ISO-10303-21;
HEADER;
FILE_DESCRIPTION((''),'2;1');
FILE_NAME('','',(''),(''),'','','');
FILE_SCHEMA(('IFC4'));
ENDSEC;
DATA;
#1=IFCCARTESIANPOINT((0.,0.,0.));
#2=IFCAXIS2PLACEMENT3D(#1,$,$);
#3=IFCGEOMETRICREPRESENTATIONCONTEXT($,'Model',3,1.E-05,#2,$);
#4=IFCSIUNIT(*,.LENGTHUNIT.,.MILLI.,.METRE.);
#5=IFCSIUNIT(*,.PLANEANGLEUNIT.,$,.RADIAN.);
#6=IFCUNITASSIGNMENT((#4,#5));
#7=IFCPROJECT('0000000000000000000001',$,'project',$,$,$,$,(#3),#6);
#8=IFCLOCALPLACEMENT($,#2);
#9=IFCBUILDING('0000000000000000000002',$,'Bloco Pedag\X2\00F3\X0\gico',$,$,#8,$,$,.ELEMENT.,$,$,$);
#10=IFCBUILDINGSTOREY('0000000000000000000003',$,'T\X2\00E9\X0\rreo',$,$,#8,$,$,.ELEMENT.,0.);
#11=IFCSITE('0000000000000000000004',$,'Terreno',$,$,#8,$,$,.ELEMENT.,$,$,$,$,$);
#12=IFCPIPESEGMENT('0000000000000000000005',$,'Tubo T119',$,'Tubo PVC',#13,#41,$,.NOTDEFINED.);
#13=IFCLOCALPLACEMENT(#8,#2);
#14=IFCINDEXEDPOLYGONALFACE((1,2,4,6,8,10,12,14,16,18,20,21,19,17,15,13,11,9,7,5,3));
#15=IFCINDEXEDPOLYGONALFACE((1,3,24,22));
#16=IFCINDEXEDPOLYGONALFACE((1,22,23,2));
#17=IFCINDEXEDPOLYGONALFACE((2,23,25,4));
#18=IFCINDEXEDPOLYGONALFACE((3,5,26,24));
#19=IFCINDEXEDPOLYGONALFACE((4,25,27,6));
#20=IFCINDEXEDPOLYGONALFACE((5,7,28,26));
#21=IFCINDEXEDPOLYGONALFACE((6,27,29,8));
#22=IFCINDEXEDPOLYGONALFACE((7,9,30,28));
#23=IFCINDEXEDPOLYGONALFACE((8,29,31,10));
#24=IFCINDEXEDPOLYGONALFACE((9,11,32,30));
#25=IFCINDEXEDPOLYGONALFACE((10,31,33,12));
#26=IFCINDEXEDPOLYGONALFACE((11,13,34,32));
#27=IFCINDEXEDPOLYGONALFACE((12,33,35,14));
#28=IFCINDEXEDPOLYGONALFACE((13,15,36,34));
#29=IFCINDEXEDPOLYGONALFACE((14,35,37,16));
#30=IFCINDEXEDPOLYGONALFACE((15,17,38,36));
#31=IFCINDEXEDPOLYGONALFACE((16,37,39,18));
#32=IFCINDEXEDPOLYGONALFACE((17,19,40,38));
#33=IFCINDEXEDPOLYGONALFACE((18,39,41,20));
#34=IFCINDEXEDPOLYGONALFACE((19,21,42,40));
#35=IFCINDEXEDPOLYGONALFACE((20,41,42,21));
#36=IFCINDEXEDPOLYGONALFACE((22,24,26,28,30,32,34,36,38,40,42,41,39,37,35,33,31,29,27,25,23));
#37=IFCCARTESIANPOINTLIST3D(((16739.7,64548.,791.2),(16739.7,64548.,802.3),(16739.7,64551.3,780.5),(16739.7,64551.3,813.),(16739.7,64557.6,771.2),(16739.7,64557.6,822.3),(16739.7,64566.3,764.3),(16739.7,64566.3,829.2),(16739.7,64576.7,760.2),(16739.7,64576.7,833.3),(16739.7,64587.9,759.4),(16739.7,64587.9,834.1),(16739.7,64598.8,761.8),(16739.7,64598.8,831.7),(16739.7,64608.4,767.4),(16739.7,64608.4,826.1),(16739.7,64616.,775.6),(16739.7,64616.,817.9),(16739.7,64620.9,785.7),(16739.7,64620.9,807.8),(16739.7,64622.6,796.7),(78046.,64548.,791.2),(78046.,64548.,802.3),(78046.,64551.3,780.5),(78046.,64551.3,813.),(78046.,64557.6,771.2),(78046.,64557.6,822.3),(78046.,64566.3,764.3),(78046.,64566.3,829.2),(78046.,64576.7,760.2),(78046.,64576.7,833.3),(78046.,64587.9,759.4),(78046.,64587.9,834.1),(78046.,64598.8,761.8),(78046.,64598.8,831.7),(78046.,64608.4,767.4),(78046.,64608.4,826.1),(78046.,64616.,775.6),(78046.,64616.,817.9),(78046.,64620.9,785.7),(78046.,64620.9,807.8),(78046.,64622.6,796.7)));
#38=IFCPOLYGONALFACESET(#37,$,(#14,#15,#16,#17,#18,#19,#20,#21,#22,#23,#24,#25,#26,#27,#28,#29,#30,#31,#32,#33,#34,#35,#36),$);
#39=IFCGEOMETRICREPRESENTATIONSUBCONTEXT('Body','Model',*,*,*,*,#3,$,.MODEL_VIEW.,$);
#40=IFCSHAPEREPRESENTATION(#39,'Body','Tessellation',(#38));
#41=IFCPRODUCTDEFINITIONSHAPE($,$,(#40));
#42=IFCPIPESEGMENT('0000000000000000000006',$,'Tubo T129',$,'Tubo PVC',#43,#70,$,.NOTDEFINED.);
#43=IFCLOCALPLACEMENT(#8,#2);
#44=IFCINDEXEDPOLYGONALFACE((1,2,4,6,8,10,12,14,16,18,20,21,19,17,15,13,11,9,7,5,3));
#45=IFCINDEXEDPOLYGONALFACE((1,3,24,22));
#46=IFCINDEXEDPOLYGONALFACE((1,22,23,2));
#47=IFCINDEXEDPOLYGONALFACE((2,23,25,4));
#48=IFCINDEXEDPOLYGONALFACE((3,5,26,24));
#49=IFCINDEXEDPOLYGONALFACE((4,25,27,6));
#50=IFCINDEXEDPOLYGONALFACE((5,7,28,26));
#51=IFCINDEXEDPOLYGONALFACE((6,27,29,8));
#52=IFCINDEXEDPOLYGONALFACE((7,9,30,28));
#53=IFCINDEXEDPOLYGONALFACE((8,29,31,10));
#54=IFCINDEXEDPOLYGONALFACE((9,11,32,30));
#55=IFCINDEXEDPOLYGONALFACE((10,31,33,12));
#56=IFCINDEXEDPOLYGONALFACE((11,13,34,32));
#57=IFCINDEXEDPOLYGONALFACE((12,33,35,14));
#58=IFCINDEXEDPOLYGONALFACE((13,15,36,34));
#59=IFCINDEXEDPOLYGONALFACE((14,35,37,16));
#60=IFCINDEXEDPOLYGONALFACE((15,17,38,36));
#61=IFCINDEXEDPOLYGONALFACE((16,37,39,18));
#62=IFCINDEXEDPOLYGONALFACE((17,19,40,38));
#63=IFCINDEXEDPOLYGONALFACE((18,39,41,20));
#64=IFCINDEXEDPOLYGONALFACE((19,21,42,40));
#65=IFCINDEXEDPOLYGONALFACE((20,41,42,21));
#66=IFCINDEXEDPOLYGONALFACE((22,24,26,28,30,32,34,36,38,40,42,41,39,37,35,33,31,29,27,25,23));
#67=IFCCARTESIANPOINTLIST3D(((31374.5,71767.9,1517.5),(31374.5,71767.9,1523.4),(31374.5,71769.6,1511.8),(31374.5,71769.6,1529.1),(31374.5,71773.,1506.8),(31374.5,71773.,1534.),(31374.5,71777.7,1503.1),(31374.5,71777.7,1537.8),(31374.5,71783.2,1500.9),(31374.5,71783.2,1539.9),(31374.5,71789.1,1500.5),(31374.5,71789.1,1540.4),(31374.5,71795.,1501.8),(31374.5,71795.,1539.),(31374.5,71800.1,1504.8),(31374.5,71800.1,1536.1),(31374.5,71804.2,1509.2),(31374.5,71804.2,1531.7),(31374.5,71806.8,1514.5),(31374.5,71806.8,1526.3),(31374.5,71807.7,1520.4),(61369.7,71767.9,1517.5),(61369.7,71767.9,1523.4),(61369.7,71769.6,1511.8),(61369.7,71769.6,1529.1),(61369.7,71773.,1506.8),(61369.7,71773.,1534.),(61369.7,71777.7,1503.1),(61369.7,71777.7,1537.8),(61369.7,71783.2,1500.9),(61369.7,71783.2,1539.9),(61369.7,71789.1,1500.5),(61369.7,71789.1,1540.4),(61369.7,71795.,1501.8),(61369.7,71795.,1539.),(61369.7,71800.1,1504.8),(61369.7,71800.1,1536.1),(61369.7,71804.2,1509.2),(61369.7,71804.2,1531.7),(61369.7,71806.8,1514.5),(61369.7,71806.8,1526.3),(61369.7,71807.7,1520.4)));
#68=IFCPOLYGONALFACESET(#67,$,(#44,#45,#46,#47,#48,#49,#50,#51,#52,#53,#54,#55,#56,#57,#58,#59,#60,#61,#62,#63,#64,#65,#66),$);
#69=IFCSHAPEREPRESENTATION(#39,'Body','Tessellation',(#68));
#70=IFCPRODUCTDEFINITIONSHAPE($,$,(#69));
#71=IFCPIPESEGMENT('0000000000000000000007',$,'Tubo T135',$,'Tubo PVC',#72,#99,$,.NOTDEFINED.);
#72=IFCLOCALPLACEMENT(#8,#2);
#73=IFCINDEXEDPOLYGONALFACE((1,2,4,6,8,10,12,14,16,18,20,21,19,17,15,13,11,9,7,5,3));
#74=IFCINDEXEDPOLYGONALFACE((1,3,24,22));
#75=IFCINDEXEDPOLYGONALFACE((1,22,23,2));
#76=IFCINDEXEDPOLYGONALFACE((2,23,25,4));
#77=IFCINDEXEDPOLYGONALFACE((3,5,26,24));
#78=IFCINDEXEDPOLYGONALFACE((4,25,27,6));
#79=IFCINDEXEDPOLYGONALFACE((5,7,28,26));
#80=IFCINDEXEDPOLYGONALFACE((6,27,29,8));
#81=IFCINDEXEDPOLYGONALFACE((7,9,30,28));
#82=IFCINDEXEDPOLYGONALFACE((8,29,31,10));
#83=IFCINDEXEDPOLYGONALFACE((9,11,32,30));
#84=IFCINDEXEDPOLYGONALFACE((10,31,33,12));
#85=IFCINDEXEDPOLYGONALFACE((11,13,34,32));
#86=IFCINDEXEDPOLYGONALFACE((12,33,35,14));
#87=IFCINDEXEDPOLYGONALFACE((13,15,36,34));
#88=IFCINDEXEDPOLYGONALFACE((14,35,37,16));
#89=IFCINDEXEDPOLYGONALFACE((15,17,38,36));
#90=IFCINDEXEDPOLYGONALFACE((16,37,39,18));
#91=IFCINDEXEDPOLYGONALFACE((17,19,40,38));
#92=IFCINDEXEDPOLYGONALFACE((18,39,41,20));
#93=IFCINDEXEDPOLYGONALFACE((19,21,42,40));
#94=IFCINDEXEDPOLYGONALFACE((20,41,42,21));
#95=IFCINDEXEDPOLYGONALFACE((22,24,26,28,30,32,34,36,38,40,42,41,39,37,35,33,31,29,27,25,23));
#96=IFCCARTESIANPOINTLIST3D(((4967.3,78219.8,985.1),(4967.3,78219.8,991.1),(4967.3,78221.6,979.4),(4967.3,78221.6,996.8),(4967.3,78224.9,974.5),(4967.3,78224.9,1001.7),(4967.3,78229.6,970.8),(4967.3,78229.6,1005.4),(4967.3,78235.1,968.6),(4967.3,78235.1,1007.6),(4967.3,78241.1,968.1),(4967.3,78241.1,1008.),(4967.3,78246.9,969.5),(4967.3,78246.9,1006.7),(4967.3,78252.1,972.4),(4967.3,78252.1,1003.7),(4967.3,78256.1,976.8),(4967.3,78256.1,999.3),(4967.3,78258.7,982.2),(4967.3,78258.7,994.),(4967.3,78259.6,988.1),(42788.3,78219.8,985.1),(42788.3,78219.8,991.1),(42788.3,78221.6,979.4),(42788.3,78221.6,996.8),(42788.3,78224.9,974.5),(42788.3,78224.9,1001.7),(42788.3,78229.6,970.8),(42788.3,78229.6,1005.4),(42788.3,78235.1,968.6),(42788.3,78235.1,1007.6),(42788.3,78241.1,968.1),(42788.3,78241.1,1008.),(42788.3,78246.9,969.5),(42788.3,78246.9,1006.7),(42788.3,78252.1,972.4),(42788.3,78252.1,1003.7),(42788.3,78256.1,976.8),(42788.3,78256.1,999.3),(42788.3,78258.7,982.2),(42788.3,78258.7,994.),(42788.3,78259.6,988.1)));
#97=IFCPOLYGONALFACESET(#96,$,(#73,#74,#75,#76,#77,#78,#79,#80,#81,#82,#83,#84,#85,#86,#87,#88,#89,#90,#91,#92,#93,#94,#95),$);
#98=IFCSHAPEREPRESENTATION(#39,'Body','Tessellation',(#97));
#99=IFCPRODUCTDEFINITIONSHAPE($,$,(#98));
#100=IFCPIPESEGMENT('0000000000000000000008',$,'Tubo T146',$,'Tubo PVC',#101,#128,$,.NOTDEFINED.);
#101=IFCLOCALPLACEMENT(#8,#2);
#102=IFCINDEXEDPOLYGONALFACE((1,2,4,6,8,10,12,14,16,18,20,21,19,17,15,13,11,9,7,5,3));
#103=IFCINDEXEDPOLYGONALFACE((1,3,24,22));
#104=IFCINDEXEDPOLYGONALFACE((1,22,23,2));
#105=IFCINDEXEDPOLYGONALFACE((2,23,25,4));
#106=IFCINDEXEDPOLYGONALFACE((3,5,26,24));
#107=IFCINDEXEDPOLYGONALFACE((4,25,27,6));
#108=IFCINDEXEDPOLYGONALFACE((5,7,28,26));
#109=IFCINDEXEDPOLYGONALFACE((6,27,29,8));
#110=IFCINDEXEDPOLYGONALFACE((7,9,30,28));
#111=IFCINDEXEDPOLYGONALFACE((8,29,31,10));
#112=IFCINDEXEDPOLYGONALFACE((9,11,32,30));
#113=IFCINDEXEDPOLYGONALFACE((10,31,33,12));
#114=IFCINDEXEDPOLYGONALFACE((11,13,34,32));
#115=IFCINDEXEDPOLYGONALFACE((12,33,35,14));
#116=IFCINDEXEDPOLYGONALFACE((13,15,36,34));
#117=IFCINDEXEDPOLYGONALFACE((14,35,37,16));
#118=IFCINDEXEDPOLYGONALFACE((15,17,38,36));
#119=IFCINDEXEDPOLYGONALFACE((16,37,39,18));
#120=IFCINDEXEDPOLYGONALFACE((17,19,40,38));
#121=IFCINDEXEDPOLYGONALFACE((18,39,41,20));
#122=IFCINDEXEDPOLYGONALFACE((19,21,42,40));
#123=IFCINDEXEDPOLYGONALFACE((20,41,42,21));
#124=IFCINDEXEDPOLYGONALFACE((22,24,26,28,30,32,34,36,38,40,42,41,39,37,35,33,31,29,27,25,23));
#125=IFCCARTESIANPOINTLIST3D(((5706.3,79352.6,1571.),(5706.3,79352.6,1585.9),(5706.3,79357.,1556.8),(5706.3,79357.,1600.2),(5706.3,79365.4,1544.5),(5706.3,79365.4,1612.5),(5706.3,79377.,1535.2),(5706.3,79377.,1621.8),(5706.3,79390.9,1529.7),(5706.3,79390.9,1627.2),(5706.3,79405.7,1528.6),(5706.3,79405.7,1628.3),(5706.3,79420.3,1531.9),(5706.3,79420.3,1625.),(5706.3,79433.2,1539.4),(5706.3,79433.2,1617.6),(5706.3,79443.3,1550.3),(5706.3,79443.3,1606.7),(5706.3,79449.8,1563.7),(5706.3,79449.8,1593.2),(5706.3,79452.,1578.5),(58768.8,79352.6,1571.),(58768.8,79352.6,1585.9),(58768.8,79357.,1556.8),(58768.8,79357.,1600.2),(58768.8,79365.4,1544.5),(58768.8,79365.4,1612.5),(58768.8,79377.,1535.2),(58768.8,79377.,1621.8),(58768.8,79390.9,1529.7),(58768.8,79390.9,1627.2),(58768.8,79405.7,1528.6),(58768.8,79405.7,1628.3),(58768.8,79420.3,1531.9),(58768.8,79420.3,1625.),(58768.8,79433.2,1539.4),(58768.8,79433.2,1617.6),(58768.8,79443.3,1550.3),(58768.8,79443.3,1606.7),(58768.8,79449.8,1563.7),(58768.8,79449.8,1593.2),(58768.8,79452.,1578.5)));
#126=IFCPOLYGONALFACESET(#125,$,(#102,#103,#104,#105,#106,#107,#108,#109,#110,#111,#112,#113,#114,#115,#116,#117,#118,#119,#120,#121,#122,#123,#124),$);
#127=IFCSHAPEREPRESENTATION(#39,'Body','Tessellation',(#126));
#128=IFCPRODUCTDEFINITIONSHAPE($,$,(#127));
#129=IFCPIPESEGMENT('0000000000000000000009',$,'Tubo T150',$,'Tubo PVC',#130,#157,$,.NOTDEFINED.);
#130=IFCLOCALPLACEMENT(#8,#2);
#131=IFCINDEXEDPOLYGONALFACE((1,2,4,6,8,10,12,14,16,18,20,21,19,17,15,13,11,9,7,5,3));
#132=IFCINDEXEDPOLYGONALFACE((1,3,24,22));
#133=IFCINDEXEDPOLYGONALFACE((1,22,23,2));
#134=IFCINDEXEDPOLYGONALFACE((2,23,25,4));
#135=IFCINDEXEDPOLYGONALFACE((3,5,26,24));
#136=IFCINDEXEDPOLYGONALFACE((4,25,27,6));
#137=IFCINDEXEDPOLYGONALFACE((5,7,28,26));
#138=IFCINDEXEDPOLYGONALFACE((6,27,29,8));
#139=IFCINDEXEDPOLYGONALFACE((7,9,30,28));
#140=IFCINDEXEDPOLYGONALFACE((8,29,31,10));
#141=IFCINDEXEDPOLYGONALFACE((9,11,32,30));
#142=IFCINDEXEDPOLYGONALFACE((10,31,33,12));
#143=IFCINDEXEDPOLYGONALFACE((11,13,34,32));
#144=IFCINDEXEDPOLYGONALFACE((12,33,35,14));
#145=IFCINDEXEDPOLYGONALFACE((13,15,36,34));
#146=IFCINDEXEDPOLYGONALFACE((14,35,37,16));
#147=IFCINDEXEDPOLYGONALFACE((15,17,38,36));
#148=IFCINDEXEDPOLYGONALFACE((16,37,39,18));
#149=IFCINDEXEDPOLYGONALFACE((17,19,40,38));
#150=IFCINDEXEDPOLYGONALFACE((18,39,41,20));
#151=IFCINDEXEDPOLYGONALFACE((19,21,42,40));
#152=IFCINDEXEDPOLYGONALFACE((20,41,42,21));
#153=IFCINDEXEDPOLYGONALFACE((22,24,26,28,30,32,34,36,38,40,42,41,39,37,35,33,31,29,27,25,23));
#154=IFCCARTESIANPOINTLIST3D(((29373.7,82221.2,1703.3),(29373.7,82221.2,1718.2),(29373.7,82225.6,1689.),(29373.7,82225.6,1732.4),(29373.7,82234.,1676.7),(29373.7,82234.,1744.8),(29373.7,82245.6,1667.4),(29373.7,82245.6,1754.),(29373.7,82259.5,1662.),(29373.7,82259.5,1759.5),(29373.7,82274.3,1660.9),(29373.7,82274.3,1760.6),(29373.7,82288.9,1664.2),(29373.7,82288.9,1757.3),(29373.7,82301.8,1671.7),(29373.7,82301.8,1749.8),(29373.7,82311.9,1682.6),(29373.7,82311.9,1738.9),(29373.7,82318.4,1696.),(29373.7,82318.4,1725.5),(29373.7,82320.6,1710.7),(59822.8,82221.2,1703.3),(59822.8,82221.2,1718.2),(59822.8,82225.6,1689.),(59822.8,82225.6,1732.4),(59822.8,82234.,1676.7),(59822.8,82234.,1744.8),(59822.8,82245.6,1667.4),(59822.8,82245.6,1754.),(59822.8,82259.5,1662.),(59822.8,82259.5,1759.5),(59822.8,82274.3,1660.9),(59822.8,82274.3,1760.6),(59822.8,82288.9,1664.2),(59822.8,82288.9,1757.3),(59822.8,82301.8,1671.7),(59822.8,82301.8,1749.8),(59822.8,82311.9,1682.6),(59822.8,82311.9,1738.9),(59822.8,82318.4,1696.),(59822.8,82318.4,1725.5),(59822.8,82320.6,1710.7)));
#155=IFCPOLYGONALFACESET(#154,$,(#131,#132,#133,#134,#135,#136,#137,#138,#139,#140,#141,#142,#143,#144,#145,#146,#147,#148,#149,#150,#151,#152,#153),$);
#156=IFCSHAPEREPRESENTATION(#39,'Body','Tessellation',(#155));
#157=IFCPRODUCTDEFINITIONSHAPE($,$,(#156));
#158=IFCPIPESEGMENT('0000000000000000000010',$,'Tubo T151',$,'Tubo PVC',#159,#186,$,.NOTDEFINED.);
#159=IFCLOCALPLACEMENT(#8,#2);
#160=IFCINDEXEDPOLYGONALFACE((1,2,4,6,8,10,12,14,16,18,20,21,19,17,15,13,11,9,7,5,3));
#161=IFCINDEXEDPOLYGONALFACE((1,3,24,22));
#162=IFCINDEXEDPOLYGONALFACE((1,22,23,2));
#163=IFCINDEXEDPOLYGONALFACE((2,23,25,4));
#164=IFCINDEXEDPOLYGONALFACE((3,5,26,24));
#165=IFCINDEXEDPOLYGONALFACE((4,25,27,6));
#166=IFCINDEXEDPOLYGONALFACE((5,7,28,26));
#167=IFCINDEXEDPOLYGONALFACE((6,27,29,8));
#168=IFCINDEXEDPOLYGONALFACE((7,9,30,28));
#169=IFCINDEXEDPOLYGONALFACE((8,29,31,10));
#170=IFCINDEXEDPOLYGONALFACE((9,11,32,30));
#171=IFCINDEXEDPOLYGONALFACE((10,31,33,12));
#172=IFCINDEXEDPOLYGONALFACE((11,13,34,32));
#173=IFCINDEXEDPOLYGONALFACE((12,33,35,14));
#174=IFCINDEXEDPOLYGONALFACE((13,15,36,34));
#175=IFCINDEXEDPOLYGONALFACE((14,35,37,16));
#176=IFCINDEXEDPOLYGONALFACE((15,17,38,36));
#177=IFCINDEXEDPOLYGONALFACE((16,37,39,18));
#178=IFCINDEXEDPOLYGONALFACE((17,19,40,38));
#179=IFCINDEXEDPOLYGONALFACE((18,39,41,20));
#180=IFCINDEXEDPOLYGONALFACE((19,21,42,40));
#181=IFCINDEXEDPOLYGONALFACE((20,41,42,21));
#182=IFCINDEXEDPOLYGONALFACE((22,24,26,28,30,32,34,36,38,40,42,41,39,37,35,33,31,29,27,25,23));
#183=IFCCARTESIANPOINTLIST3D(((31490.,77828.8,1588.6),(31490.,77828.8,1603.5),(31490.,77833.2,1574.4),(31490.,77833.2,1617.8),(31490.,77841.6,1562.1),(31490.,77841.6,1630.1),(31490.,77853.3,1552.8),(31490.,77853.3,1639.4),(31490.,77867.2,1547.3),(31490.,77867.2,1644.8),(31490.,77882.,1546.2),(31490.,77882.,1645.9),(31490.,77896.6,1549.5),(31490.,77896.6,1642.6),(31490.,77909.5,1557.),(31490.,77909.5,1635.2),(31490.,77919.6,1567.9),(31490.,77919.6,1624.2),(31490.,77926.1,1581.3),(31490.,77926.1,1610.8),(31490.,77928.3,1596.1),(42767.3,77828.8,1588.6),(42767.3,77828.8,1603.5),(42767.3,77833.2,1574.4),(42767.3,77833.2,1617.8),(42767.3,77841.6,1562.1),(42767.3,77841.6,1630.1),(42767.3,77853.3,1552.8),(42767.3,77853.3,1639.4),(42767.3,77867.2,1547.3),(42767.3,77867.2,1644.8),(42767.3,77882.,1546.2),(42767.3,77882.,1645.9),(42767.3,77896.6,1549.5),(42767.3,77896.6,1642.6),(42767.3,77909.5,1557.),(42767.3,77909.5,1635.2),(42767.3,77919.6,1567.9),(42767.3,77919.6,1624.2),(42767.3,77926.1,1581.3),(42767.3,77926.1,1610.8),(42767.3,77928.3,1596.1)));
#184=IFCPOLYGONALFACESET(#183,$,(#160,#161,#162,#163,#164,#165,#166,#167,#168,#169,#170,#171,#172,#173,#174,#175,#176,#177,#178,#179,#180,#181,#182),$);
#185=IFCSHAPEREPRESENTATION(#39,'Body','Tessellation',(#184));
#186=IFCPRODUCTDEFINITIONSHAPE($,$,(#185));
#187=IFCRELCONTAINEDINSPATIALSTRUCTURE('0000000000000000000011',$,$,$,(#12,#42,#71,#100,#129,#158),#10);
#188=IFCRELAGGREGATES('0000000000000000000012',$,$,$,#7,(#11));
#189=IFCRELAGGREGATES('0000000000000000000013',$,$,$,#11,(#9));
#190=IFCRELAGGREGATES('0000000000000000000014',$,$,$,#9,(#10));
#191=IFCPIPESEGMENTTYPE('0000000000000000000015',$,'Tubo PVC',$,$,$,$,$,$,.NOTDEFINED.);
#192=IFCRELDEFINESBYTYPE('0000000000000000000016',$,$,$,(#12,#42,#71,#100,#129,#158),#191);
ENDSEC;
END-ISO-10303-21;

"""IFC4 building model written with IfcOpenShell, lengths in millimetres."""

from ifc_helpers import new_model, si_unit, frame, origin, origin_2d, place, context, subcontext, project, spatial, circle, extrude, type_object, element, save


model = new_model("IFC4")

# Units and contexts
model_context = context("Model", 3, precision=1e-05, world=origin())
body_context = subcontext(model_context, "Body", "Model", "MODEL_VIEW")
ifc_project = project(units=[si_unit("LENGTHUNIT", "METRE", prefix="MILLI"), si_unit("PLANEANGLEUNIT", "RADIAN")], contexts=[model_context])

# Site, building, storey
placement = place(None, origin())
site = spatial("IfcSite", under=ifc_project, at=placement, Name="Terreno", CompositionType="ELEMENT")
building = spatial("IfcBuilding", under=site, at=placement, Name="Bloco Pedagógico", CompositionType="ELEMENT")
storey = spatial("IfcBuildingStorey", under=building, at=placement, Name="Térreo", CompositionType="ELEMENT", Elevation=0.0)

# Pipe segments
pipe_segment_type = type_object("IfcPipeSegmentType", Name="Tubo PVC", PredefinedType="NOTDEFINED")
pipe_segment_1_placement = place(None, frame((16739.7, 64585.1, 796.7), z_axis=(1.0, 0.0, 0.0), x_axis=(0.0, 1.0, 0.0)))
element("IfcPipeSegment", 1, at=pipe_segment_1_placement, inside=storey, type_object=pipe_segment_type, Name="Tubo T119", ObjectType="Tubo PVC", PredefinedType="NOTDEFINED", context=body_context, shape_type="SweptSolid", body=[
    extrude(circle(Radius=37.5, at=origin_2d()), None, (0.0, 0.0, 1.0), 61306.4),
])
pipe_segment_2_placement = place(None, frame((31374.5, 71787.7, 1520.4), z_axis=(1.0, 0.0, 0.0), x_axis=(0.0, 1.0, 0.0)))
element("IfcPipeSegment", 2, at=pipe_segment_2_placement, inside=storey, type_object=pipe_segment_type, Name="Tubo T129", ObjectType="Tubo PVC", PredefinedType="NOTDEFINED", context=body_context, shape_type="SweptSolid", body=[
    extrude(circle(Radius=20.0, at=origin_2d()), None, (0.0, 0.0, 1.0), 29995.3),
])
pipe_segment_3_placement = place(None, frame((4967.3, 78239.6, 988.1), z_axis=(1.0, 0.0, 0.0), x_axis=(0.0, 1.0, 0.0)))
element("IfcPipeSegment", 3, at=pipe_segment_3_placement, inside=storey, type_object=pipe_segment_type, Name="Tubo T135", ObjectType="Tubo PVC", PredefinedType="NOTDEFINED", context=body_context, shape_type="SweptSolid", body=[
    extrude(circle(Radius=20.0, at=origin_2d()), None, (0.0, 0.0, 1.0), 37821.0),
])
pipe_segment_4_placement = place(None, frame((5706.3, 79402.0, 1578.5), z_axis=(1.0, 0.0, 0.0), x_axis=(0.0, 1.0, 0.0)))
element("IfcPipeSegment", 4, at=pipe_segment_4_placement, inside=storey, type_object=pipe_segment_type, Name="Tubo T146", ObjectType="Tubo PVC", PredefinedType="NOTDEFINED", context=body_context, shape_type="SweptSolid", body=[
    extrude(circle(Radius=50.0, at=origin_2d()), None, (0.0, 0.0, 1.0), 53062.5),
])
pipe_segment_5_placement = place(None, frame((29373.7, 82270.6, 1710.7), z_axis=(1.0, 0.0, 0.0), x_axis=(0.0, 1.0, 0.0)))
element("IfcPipeSegment", 5, at=pipe_segment_5_placement, inside=storey, type_object=pipe_segment_type, Name="Tubo T150", ObjectType="Tubo PVC", PredefinedType="NOTDEFINED", context=body_context, shape_type="SweptSolid", body=[
    extrude(circle(Radius=50.0, at=origin_2d()), None, (0.0, 0.0, 1.0), 30449.1),
])
pipe_segment_6_placement = place(None, frame((31490.0, 77878.3, 1596.1), z_axis=(1.0, 0.0, 0.0), x_axis=(0.0, 1.0, 0.0)))
element("IfcPipeSegment", 6, at=pipe_segment_6_placement, inside=storey, type_object=pipe_segment_type, Name="Tubo T151", ObjectType="Tubo PVC", PredefinedType="NOTDEFINED", context=body_context, shape_type="SweptSolid", body=[
    extrude(circle(Radius=50.0, at=origin_2d()), None, (0.0, 0.0, 1.0), 11277.3),
])

save(model, "model.ifc")
